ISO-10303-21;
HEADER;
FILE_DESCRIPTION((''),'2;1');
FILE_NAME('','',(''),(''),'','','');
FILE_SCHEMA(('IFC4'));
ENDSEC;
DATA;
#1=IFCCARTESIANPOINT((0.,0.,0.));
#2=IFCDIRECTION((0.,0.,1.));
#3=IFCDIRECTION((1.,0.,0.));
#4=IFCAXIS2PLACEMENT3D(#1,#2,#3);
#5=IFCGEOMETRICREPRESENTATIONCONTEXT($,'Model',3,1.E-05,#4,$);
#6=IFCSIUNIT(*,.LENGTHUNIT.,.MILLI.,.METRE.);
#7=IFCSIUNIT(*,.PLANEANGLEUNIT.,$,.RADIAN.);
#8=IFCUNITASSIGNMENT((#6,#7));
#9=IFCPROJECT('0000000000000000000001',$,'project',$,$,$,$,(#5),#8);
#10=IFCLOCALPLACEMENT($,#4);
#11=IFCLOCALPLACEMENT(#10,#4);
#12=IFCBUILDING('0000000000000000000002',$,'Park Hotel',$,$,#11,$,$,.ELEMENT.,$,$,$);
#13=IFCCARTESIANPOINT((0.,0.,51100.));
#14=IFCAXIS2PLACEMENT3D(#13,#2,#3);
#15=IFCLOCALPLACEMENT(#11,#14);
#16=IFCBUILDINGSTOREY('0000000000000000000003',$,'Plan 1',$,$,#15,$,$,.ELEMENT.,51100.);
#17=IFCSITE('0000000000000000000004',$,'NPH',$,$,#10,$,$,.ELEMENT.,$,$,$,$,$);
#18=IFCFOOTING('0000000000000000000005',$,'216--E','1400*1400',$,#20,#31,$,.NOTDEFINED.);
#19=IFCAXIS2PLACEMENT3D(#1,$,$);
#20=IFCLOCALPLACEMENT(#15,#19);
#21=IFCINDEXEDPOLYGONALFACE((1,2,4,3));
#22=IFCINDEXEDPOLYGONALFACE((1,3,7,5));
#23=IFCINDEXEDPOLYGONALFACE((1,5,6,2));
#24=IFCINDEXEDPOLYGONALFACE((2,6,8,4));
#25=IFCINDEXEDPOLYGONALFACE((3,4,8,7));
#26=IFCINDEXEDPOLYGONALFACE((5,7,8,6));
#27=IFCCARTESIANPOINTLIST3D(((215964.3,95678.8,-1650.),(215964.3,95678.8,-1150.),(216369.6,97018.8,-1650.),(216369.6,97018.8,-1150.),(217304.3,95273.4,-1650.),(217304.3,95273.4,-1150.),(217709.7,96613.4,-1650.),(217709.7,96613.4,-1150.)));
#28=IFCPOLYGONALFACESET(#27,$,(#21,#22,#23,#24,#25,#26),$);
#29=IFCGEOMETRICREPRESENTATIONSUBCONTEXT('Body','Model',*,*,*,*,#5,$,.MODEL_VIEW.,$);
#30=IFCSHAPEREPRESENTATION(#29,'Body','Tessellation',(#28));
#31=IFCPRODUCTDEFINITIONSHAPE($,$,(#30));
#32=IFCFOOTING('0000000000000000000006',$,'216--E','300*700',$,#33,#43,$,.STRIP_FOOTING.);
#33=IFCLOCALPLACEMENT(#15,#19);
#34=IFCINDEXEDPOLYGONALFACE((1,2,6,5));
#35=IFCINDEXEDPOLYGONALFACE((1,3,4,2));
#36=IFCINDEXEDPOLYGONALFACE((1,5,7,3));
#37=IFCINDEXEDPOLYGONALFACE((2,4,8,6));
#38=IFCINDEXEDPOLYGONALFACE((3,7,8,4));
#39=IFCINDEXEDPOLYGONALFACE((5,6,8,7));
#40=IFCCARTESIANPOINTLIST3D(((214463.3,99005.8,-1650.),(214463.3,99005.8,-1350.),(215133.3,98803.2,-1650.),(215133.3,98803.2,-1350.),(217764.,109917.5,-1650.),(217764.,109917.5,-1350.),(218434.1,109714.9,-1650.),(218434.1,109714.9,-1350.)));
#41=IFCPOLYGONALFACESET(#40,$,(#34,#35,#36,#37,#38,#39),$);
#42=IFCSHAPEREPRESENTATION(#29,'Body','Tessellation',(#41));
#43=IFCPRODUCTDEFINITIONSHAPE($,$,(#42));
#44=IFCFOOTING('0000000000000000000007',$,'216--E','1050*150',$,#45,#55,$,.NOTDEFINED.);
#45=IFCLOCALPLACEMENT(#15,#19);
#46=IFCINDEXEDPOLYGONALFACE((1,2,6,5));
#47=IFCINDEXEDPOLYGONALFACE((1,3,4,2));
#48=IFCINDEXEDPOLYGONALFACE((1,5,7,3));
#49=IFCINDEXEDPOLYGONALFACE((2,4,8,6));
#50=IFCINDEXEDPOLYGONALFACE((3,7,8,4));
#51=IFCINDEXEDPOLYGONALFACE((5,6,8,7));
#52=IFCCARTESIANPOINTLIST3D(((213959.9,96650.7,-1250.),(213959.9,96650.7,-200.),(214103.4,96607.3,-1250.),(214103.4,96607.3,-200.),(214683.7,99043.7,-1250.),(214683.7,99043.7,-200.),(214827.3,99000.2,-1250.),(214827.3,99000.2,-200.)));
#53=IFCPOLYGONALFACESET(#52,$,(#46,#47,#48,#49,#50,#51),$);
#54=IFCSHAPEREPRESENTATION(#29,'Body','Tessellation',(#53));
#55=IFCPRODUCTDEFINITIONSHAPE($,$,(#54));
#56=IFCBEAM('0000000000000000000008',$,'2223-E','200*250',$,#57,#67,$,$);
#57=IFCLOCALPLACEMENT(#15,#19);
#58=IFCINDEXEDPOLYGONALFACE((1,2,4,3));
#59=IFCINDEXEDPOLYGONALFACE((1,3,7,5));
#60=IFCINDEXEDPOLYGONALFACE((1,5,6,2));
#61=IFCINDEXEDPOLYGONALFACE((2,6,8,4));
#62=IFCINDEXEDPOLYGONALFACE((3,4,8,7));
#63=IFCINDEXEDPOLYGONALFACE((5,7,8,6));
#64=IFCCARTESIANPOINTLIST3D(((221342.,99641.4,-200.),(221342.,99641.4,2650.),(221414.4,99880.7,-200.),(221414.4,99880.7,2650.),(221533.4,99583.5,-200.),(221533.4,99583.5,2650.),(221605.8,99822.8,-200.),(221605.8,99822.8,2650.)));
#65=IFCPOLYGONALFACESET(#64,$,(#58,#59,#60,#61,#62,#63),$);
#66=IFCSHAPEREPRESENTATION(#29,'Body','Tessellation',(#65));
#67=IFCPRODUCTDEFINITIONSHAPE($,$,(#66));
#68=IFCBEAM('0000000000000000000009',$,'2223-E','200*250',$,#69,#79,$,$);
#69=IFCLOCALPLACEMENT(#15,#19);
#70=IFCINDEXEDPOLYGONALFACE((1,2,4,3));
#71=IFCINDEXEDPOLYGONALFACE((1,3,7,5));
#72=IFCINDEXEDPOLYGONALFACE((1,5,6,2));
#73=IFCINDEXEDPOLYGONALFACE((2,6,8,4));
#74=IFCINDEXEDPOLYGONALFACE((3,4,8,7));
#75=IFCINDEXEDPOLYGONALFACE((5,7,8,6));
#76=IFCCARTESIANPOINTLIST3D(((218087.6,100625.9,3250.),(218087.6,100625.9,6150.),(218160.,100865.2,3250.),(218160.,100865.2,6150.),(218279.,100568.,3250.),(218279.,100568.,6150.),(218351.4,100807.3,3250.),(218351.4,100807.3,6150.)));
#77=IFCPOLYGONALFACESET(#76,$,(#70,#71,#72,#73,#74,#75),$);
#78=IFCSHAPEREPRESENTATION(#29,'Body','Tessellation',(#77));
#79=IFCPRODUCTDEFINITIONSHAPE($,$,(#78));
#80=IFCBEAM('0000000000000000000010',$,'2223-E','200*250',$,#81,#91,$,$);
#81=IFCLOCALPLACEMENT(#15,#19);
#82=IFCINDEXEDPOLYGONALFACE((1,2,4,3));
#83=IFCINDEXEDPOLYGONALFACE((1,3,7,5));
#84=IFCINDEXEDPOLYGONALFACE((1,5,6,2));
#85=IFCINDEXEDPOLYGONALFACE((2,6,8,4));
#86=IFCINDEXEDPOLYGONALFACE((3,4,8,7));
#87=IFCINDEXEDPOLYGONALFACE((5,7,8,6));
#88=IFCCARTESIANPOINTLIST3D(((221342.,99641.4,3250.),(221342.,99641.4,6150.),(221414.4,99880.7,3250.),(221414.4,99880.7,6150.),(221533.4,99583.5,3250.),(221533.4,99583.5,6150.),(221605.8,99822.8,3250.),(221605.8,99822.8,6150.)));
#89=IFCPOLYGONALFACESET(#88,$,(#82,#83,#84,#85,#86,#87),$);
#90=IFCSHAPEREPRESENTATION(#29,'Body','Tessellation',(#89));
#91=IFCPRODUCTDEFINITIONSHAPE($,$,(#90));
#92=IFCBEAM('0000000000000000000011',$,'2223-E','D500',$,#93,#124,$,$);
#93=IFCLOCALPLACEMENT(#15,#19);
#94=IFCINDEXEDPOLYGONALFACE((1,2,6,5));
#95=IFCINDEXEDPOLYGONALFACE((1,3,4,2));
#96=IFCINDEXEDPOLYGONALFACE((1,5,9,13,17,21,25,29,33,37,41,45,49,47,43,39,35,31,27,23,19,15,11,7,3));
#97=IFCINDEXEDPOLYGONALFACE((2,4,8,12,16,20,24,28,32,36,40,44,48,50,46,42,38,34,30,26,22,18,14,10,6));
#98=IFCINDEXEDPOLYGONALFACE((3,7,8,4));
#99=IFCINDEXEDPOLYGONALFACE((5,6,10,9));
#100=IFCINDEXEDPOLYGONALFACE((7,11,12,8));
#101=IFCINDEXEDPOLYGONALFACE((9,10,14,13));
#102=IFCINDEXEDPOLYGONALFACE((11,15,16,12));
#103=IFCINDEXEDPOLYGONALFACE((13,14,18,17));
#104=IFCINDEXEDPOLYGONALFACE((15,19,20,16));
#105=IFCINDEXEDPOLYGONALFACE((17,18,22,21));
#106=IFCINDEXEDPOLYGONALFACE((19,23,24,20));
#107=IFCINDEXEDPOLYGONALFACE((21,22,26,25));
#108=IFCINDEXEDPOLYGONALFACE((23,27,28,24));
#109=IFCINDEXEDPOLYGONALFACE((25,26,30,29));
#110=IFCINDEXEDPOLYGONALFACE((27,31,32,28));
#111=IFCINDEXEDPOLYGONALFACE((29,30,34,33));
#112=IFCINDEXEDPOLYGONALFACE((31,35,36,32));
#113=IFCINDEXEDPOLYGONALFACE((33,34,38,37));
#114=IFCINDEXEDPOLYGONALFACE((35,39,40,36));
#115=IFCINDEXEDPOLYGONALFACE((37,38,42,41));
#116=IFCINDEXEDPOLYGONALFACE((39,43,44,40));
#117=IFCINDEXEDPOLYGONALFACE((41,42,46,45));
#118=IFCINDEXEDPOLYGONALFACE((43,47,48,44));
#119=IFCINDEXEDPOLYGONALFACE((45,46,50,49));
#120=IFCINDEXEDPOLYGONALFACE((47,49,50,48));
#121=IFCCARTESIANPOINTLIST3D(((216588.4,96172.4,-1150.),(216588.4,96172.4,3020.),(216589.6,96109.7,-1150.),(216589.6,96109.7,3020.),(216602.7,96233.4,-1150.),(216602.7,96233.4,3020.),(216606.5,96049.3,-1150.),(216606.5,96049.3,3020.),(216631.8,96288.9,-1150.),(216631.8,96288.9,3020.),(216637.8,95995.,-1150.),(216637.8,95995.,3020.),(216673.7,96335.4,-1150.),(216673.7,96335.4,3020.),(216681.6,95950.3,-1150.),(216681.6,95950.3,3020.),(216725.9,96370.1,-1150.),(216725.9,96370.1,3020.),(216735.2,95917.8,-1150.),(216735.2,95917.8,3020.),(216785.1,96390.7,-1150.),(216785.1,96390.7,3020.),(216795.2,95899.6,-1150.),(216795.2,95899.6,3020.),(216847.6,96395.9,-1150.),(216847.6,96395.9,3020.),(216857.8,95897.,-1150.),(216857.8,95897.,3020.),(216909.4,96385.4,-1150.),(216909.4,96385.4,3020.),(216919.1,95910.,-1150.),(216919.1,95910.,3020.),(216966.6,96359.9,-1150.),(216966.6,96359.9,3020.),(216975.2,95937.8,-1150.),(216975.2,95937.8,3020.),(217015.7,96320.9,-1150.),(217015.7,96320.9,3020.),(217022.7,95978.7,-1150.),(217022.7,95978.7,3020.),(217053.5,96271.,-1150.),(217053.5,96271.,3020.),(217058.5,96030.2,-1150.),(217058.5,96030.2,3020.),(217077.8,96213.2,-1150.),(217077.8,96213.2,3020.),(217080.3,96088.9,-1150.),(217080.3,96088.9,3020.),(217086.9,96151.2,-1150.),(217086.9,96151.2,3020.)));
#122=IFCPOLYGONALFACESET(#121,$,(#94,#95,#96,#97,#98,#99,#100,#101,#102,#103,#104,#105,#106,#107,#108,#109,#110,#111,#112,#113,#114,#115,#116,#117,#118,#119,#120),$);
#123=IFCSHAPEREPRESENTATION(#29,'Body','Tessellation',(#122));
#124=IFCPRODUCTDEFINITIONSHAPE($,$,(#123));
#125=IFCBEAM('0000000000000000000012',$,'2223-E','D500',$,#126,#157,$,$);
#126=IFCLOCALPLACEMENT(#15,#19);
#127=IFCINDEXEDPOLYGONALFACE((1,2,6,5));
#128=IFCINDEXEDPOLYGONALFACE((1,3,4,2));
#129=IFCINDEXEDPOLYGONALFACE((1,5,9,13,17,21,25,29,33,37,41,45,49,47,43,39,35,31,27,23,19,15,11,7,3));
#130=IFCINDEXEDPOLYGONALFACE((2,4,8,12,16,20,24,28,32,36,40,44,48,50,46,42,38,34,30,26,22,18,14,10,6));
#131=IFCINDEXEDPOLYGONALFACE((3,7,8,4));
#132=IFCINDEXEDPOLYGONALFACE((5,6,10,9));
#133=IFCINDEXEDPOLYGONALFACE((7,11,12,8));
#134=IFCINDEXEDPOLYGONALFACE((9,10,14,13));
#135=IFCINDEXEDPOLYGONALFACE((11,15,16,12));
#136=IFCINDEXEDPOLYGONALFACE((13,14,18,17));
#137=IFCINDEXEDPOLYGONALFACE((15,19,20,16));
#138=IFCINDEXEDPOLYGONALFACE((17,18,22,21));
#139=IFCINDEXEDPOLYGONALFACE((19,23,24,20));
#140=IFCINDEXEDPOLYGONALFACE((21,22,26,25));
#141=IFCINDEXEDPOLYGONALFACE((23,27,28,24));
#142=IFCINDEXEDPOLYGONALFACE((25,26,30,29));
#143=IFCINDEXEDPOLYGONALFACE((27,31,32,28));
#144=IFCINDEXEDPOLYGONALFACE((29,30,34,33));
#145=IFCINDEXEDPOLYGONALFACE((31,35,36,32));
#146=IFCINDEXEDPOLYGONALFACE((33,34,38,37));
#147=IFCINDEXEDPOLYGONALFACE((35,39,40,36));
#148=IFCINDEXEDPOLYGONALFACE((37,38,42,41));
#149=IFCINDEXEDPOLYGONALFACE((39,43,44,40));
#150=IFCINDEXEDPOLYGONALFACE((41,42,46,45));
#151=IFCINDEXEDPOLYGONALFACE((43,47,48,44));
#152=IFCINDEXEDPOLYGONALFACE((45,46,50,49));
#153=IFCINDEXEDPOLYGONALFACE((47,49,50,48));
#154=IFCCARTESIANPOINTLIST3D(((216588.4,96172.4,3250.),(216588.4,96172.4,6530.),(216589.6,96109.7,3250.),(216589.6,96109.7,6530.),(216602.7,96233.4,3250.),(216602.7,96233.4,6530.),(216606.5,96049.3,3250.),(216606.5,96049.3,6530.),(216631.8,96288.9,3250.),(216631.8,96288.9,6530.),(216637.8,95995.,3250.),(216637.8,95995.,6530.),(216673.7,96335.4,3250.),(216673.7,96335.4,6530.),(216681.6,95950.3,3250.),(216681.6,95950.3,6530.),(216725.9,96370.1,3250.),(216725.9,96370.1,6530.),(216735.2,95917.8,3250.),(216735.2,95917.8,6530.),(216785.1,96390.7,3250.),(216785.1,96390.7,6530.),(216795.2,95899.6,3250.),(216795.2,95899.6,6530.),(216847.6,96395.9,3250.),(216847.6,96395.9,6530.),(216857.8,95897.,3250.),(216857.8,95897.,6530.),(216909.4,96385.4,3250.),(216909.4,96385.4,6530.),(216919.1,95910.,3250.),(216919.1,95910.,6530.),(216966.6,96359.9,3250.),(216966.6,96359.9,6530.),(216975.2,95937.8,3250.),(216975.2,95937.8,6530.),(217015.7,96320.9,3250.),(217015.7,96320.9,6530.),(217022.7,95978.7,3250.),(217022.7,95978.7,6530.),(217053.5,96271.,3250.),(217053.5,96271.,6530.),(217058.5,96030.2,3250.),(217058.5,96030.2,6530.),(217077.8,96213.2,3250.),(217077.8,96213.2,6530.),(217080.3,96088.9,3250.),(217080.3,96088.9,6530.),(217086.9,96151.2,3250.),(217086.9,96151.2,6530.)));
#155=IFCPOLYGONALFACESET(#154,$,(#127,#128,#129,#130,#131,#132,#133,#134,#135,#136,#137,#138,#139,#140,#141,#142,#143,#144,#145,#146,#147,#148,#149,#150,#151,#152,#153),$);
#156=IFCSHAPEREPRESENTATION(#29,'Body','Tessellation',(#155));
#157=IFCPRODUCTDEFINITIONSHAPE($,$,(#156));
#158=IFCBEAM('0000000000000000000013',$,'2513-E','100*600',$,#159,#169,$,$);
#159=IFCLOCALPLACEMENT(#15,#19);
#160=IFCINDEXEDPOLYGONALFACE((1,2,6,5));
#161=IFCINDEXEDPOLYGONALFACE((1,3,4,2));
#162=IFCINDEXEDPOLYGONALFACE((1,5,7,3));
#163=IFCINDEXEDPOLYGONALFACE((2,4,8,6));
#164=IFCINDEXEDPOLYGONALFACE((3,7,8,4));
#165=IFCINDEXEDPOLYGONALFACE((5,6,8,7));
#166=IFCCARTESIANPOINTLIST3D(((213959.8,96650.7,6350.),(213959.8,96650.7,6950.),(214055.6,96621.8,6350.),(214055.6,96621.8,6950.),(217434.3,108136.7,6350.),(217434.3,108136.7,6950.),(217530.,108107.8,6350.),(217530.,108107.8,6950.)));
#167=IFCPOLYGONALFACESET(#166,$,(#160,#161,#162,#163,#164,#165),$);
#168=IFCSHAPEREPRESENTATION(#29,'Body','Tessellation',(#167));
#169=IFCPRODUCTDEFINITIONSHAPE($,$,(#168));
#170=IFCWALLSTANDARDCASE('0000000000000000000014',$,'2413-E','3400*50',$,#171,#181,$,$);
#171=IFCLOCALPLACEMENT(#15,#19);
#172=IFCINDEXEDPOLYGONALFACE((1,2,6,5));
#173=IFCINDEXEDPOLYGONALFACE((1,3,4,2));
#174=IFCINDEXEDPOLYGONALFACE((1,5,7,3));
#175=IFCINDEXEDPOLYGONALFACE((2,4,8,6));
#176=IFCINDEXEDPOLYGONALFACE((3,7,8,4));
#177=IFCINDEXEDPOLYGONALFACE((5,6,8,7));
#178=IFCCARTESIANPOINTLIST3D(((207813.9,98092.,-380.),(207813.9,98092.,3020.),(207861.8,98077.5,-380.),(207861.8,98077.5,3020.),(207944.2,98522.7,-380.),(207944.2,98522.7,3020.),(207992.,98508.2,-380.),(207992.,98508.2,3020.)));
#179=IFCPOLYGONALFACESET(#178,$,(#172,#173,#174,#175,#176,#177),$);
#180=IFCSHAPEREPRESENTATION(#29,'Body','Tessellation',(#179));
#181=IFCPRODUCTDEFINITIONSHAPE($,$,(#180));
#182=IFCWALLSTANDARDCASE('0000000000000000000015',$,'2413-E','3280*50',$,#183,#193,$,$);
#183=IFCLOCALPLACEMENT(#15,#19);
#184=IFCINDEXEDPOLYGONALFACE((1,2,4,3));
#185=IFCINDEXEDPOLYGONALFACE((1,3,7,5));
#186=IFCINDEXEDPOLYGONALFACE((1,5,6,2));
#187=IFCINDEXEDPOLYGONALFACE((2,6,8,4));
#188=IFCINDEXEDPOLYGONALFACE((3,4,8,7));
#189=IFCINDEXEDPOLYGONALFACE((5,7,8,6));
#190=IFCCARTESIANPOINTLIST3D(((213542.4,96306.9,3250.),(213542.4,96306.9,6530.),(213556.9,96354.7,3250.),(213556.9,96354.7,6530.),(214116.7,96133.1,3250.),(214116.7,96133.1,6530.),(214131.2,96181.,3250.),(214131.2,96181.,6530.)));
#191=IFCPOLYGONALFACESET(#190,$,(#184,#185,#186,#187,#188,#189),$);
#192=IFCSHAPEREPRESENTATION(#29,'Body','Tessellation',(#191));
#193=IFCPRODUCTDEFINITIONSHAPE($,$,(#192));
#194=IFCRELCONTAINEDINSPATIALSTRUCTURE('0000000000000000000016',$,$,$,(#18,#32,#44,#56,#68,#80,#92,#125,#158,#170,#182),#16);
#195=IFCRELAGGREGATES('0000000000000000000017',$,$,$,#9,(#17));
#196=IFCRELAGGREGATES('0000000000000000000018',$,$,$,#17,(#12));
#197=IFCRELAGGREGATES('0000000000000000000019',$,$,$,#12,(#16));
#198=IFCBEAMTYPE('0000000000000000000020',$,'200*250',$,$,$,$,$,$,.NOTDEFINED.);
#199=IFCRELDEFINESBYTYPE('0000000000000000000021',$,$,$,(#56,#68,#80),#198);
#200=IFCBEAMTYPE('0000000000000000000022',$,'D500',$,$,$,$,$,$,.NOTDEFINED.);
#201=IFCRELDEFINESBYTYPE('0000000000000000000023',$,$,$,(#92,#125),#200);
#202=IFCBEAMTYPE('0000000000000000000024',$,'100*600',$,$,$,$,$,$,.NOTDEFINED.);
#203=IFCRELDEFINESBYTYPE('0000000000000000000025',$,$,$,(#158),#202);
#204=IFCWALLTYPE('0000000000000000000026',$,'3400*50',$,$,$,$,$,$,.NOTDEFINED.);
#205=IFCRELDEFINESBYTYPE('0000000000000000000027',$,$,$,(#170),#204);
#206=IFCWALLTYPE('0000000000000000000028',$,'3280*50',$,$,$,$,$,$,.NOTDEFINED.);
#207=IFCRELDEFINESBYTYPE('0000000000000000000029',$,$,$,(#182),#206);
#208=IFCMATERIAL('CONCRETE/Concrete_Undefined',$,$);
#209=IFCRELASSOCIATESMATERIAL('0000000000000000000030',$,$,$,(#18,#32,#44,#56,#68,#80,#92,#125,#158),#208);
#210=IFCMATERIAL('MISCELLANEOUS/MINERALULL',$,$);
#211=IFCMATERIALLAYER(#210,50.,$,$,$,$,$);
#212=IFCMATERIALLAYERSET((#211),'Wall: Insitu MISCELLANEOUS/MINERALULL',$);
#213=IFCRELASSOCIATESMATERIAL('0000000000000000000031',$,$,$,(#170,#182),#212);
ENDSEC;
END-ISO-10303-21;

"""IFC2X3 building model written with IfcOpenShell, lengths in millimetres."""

from ifc_helpers import new_model, si_unit, frame, frame_2d, origin_with_axes, origin_2d_with_axis, place, context, subcontext, project, spatial, rectangle, circle, extrude, material, layer, layer_set, layer_usage, type_object, element, save


model = new_model("IFC2X3")

# Units and contexts
model_context = context("Model", 3, precision=1e-05, world=origin_with_axes())
body_context = subcontext(model_context, "Body", "Model", "MODEL_VIEW")
ifc_project = project(units=[si_unit("LENGTHUNIT", "METRE", prefix="MILLI"), si_unit("PLANEANGLEUNIT", "RADIAN")], contexts=[model_context])

# Site, building, storey
site_placement = place(None, origin_with_axes())
site = spatial("IfcSite", under=ifc_project, at=site_placement, Name="NPH", CompositionType="ELEMENT")
building_placement = place(site_placement, origin_with_axes())
building = spatial("IfcBuilding", under=site, at=building_placement, Name="Park Hotel", CompositionType="ELEMENT")
storey_placement = place(building_placement, frame((0.0, 0.0, 51100.0), z_axis=(0.0, 0.0, 1.0), x_axis=(1.0, 0.0, 0.0)))
storey = spatial("IfcBuildingStorey", under=building, at=storey_placement, Name="Plan 1", CompositionType="ELEMENT", Elevation=51100.0)

# Footings
ifc_material_1 = material(Name="CONCRETE/Concrete_Undefined")
footing_1_placement = place(storey_placement, frame((216837.0, 96146.1, -1650.0), z_axis=(0.289538, 0.957167, 0.0), x_axis=(0.0, 0.0, 1.0)))
element("IfcFooting", 1, at=footing_1_placement, inside=storey, material=ifc_material_1, Name="216--E", Description="1400*1400", PredefinedType="NOTDEFINED", context=body_context, shape_type="SweptSolid", body=[
    extrude(rectangle(XDim=1400.0, YDim=1400.0, at=origin_2d_with_axis()), frame((500.0, 0.0, 0.0), z_axis=(-1.0, 0.0, 0.0), x_axis=(0.0, -1.0, 0.0)), (0.0, 0.0, 1.0), 500.0),
])
footing_2_placement = place(storey_placement, frame((214798.3, 98904.5, -1500.0), z_axis=(0.0, 0.0, 1.0), x_axis=(0.289538, 0.957167, 0.0)))
element("IfcFooting", 2, at=footing_2_placement, inside=storey, material=ifc_material_1, Name="216--E", Description="300*700", PredefinedType="STRIP_FOOTING", context=body_context, shape_type="SweptSolid", body=[
    extrude(rectangle(XDim=700.0, YDim=300.0, at=origin_2d_with_axis()), frame((11400.0, 0.0, 0.0), z_axis=(-1.0, 0.0, 0.0), x_axis=(0.0, -1.0, 0.0)), (0.0, 0.0, 1.0), 11400.0),
])
footing_3_placement = place(storey_placement, frame((214755.5, 99021.9, -725.0), z_axis=(0.0, 0.0, 1.0), x_axis=(-0.289538, -0.957167, 0.0)))
element("IfcFooting", 3, at=footing_3_placement, inside=storey, material=ifc_material_1, Name="216--E", Description="1050*150", PredefinedType="NOTDEFINED", context=body_context, shape_type="SweptSolid", body=[
    extrude(rectangle(XDim=150.0, YDim=1050.0, at=origin_2d_with_axis()), frame((2500.0, 0.0, 0.0), z_axis=(-1.0, 0.0, 0.0), x_axis=(0.0, -1.0, 0.0)), (0.0, 0.0, 1.0), 2500.0),
])

# Beams
beam_type_1 = type_object("IfcBeamType", Name="200*250", PredefinedType="NOTDEFINED")
beam_1_placement = place(storey_placement, frame((221473.9, 99732.1, -200.0), z_axis=(0.957167, -0.289538, 0.0), x_axis=(0.0, 0.0, 1.0)))
element("IfcBeam", 4, at=beam_1_placement, inside=storey, type_object=beam_type_1, material=ifc_material_1, Name="2223-E", Description="200*250", context=body_context, shape_type="SweptSolid", body=[
    extrude(rectangle(XDim=250.0, YDim=200.0, at=origin_2d_with_axis()), frame((2850.0, 0.0, 0.0), z_axis=(-1.0, 0.0, 0.0), x_axis=(0.0, -1.0, 0.0)), (0.0, 0.0, 1.0), 2850.0),
])
for number, where, z_axis, x_axis, name in (
    (5, (218219.5, 100716.6, 3250.0), (0.957167, -0.289538, 0.0), (0.0, 0.0, 1.0), "2223-E"),
    (6, (221473.9, 99732.1, 3250.0), (0.957167, -0.289538, 0.0), (0.0, 0.0, 1.0), "2223-E"),
):
    element("IfcBeam", number, at=place(storey_placement, frame(where, z_axis=z_axis, x_axis=x_axis)), inside=storey, type_object=beam_type_1, material=ifc_material_1, Name=name, Description="200*250", context=body_context, shape_type="SweptSolid", body=[
        extrude(rectangle(XDim=250.0, YDim=200.0, at=origin_2d_with_axis()), frame((2900.0, 0.0, 0.0), z_axis=(-1.0, 0.0, 0.0), x_axis=(0.0, -1.0, 0.0)), (0.0, 0.0, 1.0), 2900.0),
    ])
beam_type_2 = type_object("IfcBeamType", Name="D500", PredefinedType="NOTDEFINED")
beam_2_placement = place(storey_placement, frame((216837.0, 96146.1, -1150.0), z_axis=(0.957167, -0.289538, 0.0), x_axis=(0.0, 0.0, 1.0)))
element("IfcBeam", 7, at=beam_2_placement, inside=storey, type_object=beam_type_2, material=ifc_material_1, Name="2223-E", Description="D500", context=body_context, shape_type="SweptSolid", body=[
    extrude(circle(Radius=250.0, at=origin_2d_with_axis()), frame((4170.0, 0.0, 0.0), z_axis=(-1.0, 0.0, 0.0), x_axis=(0.0, -1.0, 0.0)), (0.0, 0.0, 1.0), 4170.0),
])
beam_3_placement = place(storey_placement, frame((216837.0, 96146.1, 3250.0), z_axis=(0.957167, -0.289538, 0.0), x_axis=(0.0, 0.0, 1.0)))
element("IfcBeam", 8, at=beam_3_placement, inside=storey, type_object=beam_type_2, material=ifc_material_1, Name="2223-E", Description="D500", context=body_context, shape_type="SweptSolid", body=[
    extrude(circle(Radius=250.0, at=origin_2d_with_axis()), frame((3280.0, 0.0, 0.0), z_axis=(-1.0, 0.0, 0.0), x_axis=(0.0, -1.0, 0.0)), (0.0, 0.0, 1.0), 3280.0),
])
beam_type_3 = type_object("IfcBeamType", Name="100*600", PredefinedType="NOTDEFINED")
beam_4_placement = place(storey_placement, frame((214007.7, 96636.3, 6650.0), z_axis=(-0.957167, 0.289538, 0.0), x_axis=(0.289538, 0.957167, 0.0)))
element("IfcBeam", 9, at=beam_4_placement, inside=storey, type_object=beam_type_3, material=ifc_material_1, Name="2513-E", Description="100*600", context=body_context, shape_type="SweptSolid", body=[
    extrude(rectangle(XDim=600.0, YDim=100.0, at=origin_2d_with_axis()), frame((12000.0, 0.0, 0.0), z_axis=(-1.0, 0.0, 0.0), x_axis=(0.0, -1.0, 0.0)), (0.0, 0.0, 1.0), 12000.0),
])

# Walls
ifc_material_2 = material(Name="MISCELLANEOUS/MINERALULL")
ifc_layer_1 = layer(ifc_material_2, 50.0)
ifc_layer_set_1 = layer_set([ifc_layer_1], Name="Wall: Insitu MISCELLANEOUS/MINERALULL")
ifc_layer_usage_1 = layer_usage(ifc_layer_set_1, "AXIS2", "POSITIVE", -25.0)
wall_type_1 = type_object("IfcWallType", Name="3400*50", PredefinedType="NOTDEFINED")
wall_1_placement = place(storey_placement, frame((207837.8, 98084.7, -380.0), z_axis=(0.0, 0.0, 1.0), x_axis=(0.289527, 0.95717, 0.0)))
element("IfcWallStandardCase", 10, at=wall_1_placement, inside=storey, type_object=wall_type_1, material=ifc_layer_usage_1, Name="2413-E", Description="3400*50", context=body_context, shape_type="SweptSolid", body=[
    extrude(rectangle(XDim=450.0, YDim=50.0, at=frame_2d((0.0, 225.0), x_axis=(0.0, -1.0))), frame((0.0, 0.0, 0.0), z_axis=(0.0, 0.0, 1.0), x_axis=(0.0, -1.0, 0.0)), (0.0, 0.0, 1.0), 3400.0),
])
ifc_layer_usage_2 = layer_usage(ifc_layer_set_1, "AXIS2", "POSITIVE", -25.0)
wall_type_2 = type_object("IfcWallType", Name="3280*50", PredefinedType="NOTDEFINED")
wall_2_placement = place(storey_placement, frame((213549.7, 96330.8, 3250.0), z_axis=(0.0, 0.0, 1.0), x_axis=(0.957166, -0.289539, 0.0)))
element("IfcWallStandardCase", 11, at=wall_2_placement, inside=storey, type_object=wall_type_2, material=ifc_layer_usage_2, Name="2413-E", Description="3280*50", context=body_context, shape_type="SweptSolid", body=[
    extrude(rectangle(XDim=600.0, YDim=50.0, at=frame_2d((0.0, 300.0), x_axis=(0.0, -1.0))), frame((0.0, 0.0, 0.0), z_axis=(0.0, 0.0, 1.0), x_axis=(0.0, -1.0, 0.0)), (0.0, 0.0, 1.0), 3280.0),
])

save(model, "model.ifc")
